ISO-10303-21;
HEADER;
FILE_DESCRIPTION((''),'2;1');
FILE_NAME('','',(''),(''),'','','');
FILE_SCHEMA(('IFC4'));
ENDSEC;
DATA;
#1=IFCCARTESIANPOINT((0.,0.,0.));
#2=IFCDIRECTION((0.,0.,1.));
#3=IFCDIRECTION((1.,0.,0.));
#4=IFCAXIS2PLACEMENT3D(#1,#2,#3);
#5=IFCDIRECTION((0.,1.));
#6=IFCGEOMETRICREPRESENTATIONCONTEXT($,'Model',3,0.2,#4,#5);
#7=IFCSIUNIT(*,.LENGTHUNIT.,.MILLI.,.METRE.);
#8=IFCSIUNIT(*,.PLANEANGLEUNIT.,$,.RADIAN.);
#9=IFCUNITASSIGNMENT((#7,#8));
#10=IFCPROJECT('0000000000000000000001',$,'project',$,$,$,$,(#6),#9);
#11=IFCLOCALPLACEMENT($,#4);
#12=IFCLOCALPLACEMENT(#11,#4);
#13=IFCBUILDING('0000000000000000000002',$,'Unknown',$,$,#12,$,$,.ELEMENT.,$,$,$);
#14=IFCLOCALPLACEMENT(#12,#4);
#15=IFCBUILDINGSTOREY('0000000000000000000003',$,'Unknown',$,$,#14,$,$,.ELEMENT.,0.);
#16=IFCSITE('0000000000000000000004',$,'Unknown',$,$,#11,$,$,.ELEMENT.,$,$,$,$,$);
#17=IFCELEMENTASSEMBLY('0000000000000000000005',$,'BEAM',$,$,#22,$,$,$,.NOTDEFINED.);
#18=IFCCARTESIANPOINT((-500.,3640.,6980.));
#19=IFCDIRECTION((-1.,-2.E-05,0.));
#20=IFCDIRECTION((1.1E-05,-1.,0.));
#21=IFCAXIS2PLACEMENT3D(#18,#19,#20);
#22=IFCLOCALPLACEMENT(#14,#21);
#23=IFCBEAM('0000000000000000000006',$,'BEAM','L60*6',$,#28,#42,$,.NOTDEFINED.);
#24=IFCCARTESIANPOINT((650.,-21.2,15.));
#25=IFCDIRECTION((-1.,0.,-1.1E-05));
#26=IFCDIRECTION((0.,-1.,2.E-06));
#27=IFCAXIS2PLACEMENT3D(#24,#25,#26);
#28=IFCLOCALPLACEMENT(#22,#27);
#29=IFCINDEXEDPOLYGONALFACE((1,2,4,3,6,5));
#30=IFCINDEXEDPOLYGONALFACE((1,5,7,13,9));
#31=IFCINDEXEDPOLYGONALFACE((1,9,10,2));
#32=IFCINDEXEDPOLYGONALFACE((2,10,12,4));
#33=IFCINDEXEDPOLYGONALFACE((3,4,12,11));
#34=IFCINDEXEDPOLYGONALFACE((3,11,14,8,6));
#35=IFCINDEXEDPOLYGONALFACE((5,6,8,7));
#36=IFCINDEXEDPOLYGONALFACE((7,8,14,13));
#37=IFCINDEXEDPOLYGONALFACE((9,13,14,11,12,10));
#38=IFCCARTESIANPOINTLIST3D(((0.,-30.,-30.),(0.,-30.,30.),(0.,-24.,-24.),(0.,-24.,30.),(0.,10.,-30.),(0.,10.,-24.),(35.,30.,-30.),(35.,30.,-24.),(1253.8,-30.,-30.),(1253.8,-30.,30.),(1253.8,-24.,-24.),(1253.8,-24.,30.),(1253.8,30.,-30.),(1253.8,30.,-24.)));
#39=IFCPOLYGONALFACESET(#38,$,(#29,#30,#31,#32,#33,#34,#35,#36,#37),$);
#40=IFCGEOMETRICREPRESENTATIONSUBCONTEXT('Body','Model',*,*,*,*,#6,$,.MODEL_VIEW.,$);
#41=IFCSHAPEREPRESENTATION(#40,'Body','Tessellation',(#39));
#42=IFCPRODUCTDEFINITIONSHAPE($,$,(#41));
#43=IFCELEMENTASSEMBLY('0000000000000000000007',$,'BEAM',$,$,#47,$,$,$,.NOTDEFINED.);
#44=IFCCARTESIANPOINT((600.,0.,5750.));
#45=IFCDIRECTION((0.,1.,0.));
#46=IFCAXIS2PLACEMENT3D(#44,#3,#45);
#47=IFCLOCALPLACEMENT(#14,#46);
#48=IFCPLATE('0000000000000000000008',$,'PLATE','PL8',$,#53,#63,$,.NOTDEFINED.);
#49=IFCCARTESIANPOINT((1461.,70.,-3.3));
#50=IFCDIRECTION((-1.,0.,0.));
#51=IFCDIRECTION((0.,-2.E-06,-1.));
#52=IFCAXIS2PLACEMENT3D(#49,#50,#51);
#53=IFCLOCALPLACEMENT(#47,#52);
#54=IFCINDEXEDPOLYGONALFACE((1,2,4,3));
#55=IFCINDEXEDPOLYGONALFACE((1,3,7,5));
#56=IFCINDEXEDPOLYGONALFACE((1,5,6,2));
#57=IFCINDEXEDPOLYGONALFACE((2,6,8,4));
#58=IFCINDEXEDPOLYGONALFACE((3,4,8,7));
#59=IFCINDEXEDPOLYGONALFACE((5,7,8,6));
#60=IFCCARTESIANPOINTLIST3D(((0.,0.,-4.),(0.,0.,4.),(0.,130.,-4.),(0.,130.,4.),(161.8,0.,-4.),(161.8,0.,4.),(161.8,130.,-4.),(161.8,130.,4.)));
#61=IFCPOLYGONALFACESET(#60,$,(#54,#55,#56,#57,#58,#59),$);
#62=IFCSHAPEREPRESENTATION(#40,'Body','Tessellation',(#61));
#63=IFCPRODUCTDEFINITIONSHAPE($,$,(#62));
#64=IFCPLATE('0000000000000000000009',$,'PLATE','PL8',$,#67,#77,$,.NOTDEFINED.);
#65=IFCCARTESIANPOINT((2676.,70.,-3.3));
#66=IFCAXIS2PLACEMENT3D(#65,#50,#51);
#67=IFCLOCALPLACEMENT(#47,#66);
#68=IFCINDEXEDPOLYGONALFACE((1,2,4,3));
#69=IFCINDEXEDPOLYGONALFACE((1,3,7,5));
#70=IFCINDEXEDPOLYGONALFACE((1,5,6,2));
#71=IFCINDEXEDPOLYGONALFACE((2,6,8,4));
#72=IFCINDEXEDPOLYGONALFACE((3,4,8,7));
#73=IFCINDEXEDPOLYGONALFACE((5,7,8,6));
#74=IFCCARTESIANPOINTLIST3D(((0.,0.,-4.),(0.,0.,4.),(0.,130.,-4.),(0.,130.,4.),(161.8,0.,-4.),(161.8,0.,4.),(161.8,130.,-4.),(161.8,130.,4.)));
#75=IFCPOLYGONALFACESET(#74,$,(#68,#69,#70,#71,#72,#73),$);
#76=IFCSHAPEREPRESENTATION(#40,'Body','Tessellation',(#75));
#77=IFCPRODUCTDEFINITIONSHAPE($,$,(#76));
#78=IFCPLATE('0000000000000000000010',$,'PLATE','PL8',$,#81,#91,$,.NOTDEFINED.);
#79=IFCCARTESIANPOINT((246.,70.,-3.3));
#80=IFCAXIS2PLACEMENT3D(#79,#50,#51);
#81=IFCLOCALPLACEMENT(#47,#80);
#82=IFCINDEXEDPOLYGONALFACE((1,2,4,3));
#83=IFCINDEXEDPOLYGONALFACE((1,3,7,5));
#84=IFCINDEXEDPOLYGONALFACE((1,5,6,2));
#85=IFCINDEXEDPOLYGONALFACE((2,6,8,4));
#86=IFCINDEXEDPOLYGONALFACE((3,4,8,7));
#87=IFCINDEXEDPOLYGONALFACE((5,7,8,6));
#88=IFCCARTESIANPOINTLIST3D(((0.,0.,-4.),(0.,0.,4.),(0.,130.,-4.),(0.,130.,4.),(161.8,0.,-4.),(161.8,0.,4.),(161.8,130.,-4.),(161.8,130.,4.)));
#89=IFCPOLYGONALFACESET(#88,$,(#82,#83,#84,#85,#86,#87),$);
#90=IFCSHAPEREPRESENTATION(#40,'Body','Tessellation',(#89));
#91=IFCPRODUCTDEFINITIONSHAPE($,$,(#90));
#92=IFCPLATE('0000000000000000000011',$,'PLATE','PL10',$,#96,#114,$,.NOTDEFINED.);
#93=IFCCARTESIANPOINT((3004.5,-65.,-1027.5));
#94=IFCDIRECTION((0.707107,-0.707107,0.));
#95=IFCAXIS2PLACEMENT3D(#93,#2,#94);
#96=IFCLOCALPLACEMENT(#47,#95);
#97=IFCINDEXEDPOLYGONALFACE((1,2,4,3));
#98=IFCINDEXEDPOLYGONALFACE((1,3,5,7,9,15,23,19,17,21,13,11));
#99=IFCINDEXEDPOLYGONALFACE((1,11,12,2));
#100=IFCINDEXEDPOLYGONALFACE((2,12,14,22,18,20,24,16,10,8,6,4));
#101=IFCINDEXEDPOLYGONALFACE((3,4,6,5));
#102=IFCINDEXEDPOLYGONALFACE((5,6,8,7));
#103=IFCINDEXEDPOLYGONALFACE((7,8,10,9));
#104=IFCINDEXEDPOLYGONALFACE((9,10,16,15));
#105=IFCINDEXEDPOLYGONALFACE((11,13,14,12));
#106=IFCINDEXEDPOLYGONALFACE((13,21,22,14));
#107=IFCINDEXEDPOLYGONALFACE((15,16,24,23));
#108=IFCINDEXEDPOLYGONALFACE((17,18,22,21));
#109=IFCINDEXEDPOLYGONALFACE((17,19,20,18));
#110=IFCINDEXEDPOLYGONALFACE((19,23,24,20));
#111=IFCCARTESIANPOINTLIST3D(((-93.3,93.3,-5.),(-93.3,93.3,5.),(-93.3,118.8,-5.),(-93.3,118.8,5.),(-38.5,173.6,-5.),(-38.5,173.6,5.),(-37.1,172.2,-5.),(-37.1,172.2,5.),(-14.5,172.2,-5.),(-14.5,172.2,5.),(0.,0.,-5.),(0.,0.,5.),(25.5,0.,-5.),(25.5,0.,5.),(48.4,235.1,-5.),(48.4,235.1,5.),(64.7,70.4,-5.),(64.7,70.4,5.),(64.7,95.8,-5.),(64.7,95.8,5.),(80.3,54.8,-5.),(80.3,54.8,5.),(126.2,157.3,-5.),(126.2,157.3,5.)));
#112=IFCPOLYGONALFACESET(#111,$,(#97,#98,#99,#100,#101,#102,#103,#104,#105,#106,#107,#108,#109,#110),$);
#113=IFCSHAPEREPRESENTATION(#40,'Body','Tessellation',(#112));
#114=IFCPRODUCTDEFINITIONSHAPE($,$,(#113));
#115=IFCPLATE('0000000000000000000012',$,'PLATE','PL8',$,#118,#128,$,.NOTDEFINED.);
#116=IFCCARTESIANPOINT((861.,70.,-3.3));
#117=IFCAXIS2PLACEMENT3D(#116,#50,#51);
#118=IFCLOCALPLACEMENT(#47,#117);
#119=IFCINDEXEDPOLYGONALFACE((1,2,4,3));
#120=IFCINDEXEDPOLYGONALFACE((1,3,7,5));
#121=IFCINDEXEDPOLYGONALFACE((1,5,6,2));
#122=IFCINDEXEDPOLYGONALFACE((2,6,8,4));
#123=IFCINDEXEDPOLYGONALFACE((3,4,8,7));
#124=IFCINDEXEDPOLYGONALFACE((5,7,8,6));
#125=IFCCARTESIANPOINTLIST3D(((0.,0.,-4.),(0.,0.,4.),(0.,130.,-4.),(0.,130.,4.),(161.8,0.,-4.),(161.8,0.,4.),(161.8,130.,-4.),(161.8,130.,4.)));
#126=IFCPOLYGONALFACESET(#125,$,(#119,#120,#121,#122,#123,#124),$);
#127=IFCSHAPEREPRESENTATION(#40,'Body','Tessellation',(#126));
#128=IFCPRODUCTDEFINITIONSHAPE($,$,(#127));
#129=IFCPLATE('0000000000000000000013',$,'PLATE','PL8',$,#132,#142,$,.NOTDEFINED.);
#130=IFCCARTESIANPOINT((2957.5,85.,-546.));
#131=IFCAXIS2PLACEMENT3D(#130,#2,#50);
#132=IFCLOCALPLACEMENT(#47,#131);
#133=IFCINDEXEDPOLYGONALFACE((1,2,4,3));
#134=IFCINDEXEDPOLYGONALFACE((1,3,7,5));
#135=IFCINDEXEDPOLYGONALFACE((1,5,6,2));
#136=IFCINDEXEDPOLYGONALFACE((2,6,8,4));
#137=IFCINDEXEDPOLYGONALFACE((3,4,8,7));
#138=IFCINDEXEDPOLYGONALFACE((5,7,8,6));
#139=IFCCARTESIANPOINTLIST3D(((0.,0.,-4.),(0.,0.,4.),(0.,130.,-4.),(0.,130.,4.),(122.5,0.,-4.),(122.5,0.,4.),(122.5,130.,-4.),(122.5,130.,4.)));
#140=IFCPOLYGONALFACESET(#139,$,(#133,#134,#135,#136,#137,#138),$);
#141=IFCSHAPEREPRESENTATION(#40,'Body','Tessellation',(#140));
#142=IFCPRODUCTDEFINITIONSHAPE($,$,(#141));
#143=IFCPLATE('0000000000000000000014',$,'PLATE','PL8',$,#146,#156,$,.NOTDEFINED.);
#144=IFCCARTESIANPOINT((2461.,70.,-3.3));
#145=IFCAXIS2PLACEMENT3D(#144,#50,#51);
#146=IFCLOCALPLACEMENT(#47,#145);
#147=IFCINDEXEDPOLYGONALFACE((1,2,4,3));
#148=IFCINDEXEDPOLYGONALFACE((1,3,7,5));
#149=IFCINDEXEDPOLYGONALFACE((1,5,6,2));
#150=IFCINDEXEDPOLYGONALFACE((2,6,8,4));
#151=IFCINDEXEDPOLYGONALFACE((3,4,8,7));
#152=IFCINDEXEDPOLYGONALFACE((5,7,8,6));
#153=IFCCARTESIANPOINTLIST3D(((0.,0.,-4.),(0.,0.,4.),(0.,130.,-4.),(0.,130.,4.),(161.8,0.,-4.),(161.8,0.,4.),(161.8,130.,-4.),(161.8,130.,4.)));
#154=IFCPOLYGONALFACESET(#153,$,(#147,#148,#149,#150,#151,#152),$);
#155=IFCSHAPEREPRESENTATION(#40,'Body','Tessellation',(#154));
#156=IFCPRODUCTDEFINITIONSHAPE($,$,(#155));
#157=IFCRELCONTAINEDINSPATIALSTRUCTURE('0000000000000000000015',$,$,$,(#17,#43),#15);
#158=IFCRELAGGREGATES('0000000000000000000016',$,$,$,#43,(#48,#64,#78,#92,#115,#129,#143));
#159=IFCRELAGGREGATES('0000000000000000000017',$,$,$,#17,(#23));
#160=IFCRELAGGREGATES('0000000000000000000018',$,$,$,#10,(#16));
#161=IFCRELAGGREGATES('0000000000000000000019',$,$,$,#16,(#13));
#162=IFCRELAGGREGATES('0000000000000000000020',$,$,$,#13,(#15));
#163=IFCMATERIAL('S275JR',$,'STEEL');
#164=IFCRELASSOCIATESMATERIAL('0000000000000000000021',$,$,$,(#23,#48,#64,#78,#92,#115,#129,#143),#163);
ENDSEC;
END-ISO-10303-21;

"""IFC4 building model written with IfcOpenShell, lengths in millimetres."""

from ifc_helpers import new_model, si_unit, direction, frame, origin_with_axes, place, context, subcontext, project, spatial, line, indexed_curve, outline, extrude, material, element, aggregate, save


model = new_model("IFC4")

# Units and contexts
model_context = context("Model", 3, precision=0.2, world=origin_with_axes(), true_north=direction((0.0, 1.0)))
body_context = subcontext(model_context, "Body", "Model", "MODEL_VIEW")
ifc_project = project(units=[si_unit("LENGTHUNIT", "METRE", prefix="MILLI"), si_unit("PLANEANGLEUNIT", "RADIAN")], contexts=[model_context])

# Site, building, storey
site_placement = place(None, origin_with_axes())
site = spatial("IfcSite", under=ifc_project, at=site_placement, Name="Unknown", CompositionType="ELEMENT")
building_placement = place(site_placement, origin_with_axes())
building = spatial("IfcBuilding", under=site, at=building_placement, Name="Unknown", CompositionType="ELEMENT")
storey_placement = place(building_placement, origin_with_axes())
storey = spatial("IfcBuildingStorey", under=building, at=storey_placement, Name="Unknown", CompositionType="ELEMENT", Elevation=0.0)

# Element assembly
ifc_material_1 = material(Name="S275JR", Category="STEEL")
assembly_1_placement = place(storey_placement, frame((-500.0, 3640.0, 6980.0), z_axis=(-1.0, -0.00002, 0.0), x_axis=(0.000011, -1.0, 0.0)))
assembly_1 = element("IfcElementAssembly", 1, at=assembly_1_placement, inside=storey, Name="BEAM", PredefinedType="NOTDEFINED")

# Beam, voiding feature
beam_1_placement = place(assembly_1_placement, frame((650.0, -21.2, 15.0), z_axis=(-1.0, 0.0, -0.000011), x_axis=(0.0, -1.0, 0.000002)))
beam_1 = element("IfcBeam", 2, at=beam_1_placement, material=ifc_material_1, Name="BEAM", Description="L60*6", PredefinedType="NOTDEFINED", context=body_context, shape_type="SolidModel", body=[
    extrude(outline(indexed_curve([(-30.0, -30.0), (30.0, -30.0), (30.0, -24.0), (-24.0, -24.0), (-24.0, 30.0), (-30.0, 30.0)], segments=[line(1, 2, 3, 4, 5, 6, 1)])), frame((0.0, 0.0, 0.0), z_axis=(-1.0, 0.0, 0.0), x_axis=(0.0, 0.0, 1.0)), (0.0, -0.000002, -1.0), 1253.8),
])
voiding_feature_1_placement = place(beam_1_placement, frame((0.0, 10.0, 0.0), z_axis=(0.0, -0.000002, -1.0), x_axis=(0.0, 1.0, 0.0)))
element("IfcVoidingFeature", 3, at=voiding_feature_1_placement, cuts=beam_1, Name="CUTPART", PredefinedType="HOLE", context=body_context, shape_type="SolidModel", body=[
    extrude(outline(indexed_curve([(0.0, 0.0), (20.0, 0.0), (20.0, 35.0)], segments=[line(1, 2, 3, 1)])), frame((0.0, 0.0, 33.0), z_axis=(0.0, 0.0, 1.0), x_axis=(1.0, 0.0, 0.0)), (0.0, -0.000002, -1.0), 66.0),
])

# Element assembly, plates
assembly_2_placement = place(storey_placement, frame((600.0, 0.0, 5750.0), z_axis=(1.0, 0.0, 0.0), x_axis=(0.0, 1.0, 0.0)))
assembly_2 = element("IfcElementAssembly", 4, at=assembly_2_placement, inside=storey, Name="BEAM", PredefinedType="NOTDEFINED")
plate_1_placement = place(assembly_2_placement, frame((1461.0, 70.0, -3.3), z_axis=(-1.0, 0.0, 0.0), x_axis=(0.0, -0.000002, -1.0)))
plate_1 = element("IfcPlate", 5, at=plate_1_placement, material=ifc_material_1, Name="PLATE", Description="PL8", PredefinedType="NOTDEFINED", context=body_context, shape_type="SolidModel", body=[
    extrude(outline(indexed_curve([(0.0, 0.0), (161.8, 0.0), (161.8, 130.0), (0.0, 130.0)], segments=[line(1, 2, 3, 4, 1)])), frame((0.0, 0.0, 4.0), z_axis=(0.0, 0.0, 1.0), x_axis=(1.0, 0.0, 0.0)), (0.0, -0.000002, -1.0), 8.0),
])
plate_2_placement = place(assembly_2_placement, frame((2676.0, 70.0, -3.3), z_axis=(-1.0, 0.0, 0.0), x_axis=(0.0, -0.000002, -1.0)))
plate_2 = element("IfcPlate", 6, at=plate_2_placement, material=ifc_material_1, Name="PLATE", Description="PL8", PredefinedType="NOTDEFINED", context=body_context, shape_type="SolidModel", body=[
    extrude(outline(indexed_curve([(0.0, 0.0), (161.8, 0.0), (161.8, 130.0), (0.0, 130.0)], segments=[line(1, 2, 3, 4, 1)])), frame((0.0, 0.0, 4.0), z_axis=(0.0, 0.0, 1.0), x_axis=(1.0, 0.0, 0.0)), (0.0, -0.000002, -1.0), 8.0),
])
plate_3_placement = place(assembly_2_placement, frame((246.0, 70.0, -3.3), z_axis=(-1.0, 0.0, 0.0), x_axis=(0.0, -0.000002, -1.0)))
plate_3 = element("IfcPlate", 7, at=plate_3_placement, material=ifc_material_1, Name="PLATE", Description="PL8", PredefinedType="NOTDEFINED", context=body_context, shape_type="SolidModel", body=[
    extrude(outline(indexed_curve([(0.0, 0.0), (161.8, 0.0), (161.8, 130.0), (0.0, 130.0)], segments=[line(1, 2, 3, 4, 1)])), frame((0.0, 0.0, 4.0), z_axis=(0.0, 0.0, 1.0), x_axis=(1.0, 0.0, 0.0)), (0.0, -0.000002, -1.0), 8.0),
])
plate_4_placement = place(assembly_2_placement, frame((3004.5, -65.0, -1027.5), z_axis=(0.0, 0.0, 1.0), x_axis=(0.707107, -0.707107, 0.0)))
plate_4 = element("IfcPlate", 8, at=plate_4_placement, material=ifc_material_1, Name="PLATE", Description="PL10", PredefinedType="NOTDEFINED", context=body_context, shape_type="SolidModel", body=[
    extrude(outline(indexed_curve([(0.0, 0.0), (25.5, 0.0), (80.3, 54.8), (64.7, 70.4), (64.7, 95.8), (126.2, 157.3), (48.4, 235.1), (-14.5, 172.2), (-37.1, 172.2), (-38.5, 173.6), (-93.3, 118.8), (-93.3, 93.3)], segments=[line(1, 2, 3, 4, 5, 6, 7, 8, 9, 10, 11, 12, 1)])), frame((0.0, 0.0, 5.0), z_axis=(0.0, 0.0, 1.0), x_axis=(1.0, 0.0, 0.0)), (0.0, -0.000002, -1.0), 10.0),
])
plate_5_placement = place(assembly_2_placement, frame((861.0, 70.0, -3.3), z_axis=(-1.0, 0.0, 0.0), x_axis=(0.0, -0.000002, -1.0)))
plate_5 = element("IfcPlate", 9, at=plate_5_placement, material=ifc_material_1, Name="PLATE", Description="PL8", PredefinedType="NOTDEFINED", context=body_context, shape_type="SolidModel", body=[
    extrude(outline(indexed_curve([(0.0, 0.0), (161.8, 0.0), (161.8, 130.0), (0.0, 130.0)], segments=[line(1, 2, 3, 4, 1)])), frame((0.0, 0.0, 4.0), z_axis=(0.0, 0.0, 1.0), x_axis=(1.0, 0.0, 0.0)), (0.0, -0.000002, -1.0), 8.0),
])
plate_6_placement = place(assembly_2_placement, frame((2957.5, 85.0, -546.0), z_axis=(0.0, 0.0, 1.0), x_axis=(-1.0, 0.0, 0.0)))
plate_6 = element("IfcPlate", 10, at=plate_6_placement, material=ifc_material_1, Name="PLATE", Description="PL8", PredefinedType="NOTDEFINED", context=body_context, shape_type="SolidModel", body=[
    extrude(outline(indexed_curve([(0.0, 0.0), (122.5, 0.0), (122.5, 130.0), (0.0, 130.0)], segments=[line(1, 2, 3, 4, 1)])), frame((0.0, 0.0, 4.0), z_axis=(0.0, 0.0, 1.0), x_axis=(1.0, 0.0, 0.0)), (0.0, -0.000002, -1.0), 8.0),
])
plate_7_placement = place(assembly_2_placement, frame((2461.0, 70.0, -3.3), z_axis=(-1.0, 0.0, 0.0), x_axis=(0.0, -0.000002, -1.0)))
plate_7 = element("IfcPlate", 11, at=plate_7_placement, material=ifc_material_1, Name="PLATE", Description="PL8", PredefinedType="NOTDEFINED", context=body_context, shape_type="SolidModel", body=[
    extrude(outline(indexed_curve([(0.0, 0.0), (161.8, 0.0), (161.8, 130.0), (0.0, 130.0)], segments=[line(1, 2, 3, 4, 1)])), frame((0.0, 0.0, 4.0), z_axis=(0.0, 0.0, 1.0), x_axis=(1.0, 0.0, 0.0)), (0.0, -0.000002, -1.0), 8.0),
])
aggregate(assembly_2, [plate_1, plate_2, plate_3, plate_4, plate_5, plate_6, plate_7])

aggregate(assembly_1, [beam_1])

save(model, "model.ifc")
